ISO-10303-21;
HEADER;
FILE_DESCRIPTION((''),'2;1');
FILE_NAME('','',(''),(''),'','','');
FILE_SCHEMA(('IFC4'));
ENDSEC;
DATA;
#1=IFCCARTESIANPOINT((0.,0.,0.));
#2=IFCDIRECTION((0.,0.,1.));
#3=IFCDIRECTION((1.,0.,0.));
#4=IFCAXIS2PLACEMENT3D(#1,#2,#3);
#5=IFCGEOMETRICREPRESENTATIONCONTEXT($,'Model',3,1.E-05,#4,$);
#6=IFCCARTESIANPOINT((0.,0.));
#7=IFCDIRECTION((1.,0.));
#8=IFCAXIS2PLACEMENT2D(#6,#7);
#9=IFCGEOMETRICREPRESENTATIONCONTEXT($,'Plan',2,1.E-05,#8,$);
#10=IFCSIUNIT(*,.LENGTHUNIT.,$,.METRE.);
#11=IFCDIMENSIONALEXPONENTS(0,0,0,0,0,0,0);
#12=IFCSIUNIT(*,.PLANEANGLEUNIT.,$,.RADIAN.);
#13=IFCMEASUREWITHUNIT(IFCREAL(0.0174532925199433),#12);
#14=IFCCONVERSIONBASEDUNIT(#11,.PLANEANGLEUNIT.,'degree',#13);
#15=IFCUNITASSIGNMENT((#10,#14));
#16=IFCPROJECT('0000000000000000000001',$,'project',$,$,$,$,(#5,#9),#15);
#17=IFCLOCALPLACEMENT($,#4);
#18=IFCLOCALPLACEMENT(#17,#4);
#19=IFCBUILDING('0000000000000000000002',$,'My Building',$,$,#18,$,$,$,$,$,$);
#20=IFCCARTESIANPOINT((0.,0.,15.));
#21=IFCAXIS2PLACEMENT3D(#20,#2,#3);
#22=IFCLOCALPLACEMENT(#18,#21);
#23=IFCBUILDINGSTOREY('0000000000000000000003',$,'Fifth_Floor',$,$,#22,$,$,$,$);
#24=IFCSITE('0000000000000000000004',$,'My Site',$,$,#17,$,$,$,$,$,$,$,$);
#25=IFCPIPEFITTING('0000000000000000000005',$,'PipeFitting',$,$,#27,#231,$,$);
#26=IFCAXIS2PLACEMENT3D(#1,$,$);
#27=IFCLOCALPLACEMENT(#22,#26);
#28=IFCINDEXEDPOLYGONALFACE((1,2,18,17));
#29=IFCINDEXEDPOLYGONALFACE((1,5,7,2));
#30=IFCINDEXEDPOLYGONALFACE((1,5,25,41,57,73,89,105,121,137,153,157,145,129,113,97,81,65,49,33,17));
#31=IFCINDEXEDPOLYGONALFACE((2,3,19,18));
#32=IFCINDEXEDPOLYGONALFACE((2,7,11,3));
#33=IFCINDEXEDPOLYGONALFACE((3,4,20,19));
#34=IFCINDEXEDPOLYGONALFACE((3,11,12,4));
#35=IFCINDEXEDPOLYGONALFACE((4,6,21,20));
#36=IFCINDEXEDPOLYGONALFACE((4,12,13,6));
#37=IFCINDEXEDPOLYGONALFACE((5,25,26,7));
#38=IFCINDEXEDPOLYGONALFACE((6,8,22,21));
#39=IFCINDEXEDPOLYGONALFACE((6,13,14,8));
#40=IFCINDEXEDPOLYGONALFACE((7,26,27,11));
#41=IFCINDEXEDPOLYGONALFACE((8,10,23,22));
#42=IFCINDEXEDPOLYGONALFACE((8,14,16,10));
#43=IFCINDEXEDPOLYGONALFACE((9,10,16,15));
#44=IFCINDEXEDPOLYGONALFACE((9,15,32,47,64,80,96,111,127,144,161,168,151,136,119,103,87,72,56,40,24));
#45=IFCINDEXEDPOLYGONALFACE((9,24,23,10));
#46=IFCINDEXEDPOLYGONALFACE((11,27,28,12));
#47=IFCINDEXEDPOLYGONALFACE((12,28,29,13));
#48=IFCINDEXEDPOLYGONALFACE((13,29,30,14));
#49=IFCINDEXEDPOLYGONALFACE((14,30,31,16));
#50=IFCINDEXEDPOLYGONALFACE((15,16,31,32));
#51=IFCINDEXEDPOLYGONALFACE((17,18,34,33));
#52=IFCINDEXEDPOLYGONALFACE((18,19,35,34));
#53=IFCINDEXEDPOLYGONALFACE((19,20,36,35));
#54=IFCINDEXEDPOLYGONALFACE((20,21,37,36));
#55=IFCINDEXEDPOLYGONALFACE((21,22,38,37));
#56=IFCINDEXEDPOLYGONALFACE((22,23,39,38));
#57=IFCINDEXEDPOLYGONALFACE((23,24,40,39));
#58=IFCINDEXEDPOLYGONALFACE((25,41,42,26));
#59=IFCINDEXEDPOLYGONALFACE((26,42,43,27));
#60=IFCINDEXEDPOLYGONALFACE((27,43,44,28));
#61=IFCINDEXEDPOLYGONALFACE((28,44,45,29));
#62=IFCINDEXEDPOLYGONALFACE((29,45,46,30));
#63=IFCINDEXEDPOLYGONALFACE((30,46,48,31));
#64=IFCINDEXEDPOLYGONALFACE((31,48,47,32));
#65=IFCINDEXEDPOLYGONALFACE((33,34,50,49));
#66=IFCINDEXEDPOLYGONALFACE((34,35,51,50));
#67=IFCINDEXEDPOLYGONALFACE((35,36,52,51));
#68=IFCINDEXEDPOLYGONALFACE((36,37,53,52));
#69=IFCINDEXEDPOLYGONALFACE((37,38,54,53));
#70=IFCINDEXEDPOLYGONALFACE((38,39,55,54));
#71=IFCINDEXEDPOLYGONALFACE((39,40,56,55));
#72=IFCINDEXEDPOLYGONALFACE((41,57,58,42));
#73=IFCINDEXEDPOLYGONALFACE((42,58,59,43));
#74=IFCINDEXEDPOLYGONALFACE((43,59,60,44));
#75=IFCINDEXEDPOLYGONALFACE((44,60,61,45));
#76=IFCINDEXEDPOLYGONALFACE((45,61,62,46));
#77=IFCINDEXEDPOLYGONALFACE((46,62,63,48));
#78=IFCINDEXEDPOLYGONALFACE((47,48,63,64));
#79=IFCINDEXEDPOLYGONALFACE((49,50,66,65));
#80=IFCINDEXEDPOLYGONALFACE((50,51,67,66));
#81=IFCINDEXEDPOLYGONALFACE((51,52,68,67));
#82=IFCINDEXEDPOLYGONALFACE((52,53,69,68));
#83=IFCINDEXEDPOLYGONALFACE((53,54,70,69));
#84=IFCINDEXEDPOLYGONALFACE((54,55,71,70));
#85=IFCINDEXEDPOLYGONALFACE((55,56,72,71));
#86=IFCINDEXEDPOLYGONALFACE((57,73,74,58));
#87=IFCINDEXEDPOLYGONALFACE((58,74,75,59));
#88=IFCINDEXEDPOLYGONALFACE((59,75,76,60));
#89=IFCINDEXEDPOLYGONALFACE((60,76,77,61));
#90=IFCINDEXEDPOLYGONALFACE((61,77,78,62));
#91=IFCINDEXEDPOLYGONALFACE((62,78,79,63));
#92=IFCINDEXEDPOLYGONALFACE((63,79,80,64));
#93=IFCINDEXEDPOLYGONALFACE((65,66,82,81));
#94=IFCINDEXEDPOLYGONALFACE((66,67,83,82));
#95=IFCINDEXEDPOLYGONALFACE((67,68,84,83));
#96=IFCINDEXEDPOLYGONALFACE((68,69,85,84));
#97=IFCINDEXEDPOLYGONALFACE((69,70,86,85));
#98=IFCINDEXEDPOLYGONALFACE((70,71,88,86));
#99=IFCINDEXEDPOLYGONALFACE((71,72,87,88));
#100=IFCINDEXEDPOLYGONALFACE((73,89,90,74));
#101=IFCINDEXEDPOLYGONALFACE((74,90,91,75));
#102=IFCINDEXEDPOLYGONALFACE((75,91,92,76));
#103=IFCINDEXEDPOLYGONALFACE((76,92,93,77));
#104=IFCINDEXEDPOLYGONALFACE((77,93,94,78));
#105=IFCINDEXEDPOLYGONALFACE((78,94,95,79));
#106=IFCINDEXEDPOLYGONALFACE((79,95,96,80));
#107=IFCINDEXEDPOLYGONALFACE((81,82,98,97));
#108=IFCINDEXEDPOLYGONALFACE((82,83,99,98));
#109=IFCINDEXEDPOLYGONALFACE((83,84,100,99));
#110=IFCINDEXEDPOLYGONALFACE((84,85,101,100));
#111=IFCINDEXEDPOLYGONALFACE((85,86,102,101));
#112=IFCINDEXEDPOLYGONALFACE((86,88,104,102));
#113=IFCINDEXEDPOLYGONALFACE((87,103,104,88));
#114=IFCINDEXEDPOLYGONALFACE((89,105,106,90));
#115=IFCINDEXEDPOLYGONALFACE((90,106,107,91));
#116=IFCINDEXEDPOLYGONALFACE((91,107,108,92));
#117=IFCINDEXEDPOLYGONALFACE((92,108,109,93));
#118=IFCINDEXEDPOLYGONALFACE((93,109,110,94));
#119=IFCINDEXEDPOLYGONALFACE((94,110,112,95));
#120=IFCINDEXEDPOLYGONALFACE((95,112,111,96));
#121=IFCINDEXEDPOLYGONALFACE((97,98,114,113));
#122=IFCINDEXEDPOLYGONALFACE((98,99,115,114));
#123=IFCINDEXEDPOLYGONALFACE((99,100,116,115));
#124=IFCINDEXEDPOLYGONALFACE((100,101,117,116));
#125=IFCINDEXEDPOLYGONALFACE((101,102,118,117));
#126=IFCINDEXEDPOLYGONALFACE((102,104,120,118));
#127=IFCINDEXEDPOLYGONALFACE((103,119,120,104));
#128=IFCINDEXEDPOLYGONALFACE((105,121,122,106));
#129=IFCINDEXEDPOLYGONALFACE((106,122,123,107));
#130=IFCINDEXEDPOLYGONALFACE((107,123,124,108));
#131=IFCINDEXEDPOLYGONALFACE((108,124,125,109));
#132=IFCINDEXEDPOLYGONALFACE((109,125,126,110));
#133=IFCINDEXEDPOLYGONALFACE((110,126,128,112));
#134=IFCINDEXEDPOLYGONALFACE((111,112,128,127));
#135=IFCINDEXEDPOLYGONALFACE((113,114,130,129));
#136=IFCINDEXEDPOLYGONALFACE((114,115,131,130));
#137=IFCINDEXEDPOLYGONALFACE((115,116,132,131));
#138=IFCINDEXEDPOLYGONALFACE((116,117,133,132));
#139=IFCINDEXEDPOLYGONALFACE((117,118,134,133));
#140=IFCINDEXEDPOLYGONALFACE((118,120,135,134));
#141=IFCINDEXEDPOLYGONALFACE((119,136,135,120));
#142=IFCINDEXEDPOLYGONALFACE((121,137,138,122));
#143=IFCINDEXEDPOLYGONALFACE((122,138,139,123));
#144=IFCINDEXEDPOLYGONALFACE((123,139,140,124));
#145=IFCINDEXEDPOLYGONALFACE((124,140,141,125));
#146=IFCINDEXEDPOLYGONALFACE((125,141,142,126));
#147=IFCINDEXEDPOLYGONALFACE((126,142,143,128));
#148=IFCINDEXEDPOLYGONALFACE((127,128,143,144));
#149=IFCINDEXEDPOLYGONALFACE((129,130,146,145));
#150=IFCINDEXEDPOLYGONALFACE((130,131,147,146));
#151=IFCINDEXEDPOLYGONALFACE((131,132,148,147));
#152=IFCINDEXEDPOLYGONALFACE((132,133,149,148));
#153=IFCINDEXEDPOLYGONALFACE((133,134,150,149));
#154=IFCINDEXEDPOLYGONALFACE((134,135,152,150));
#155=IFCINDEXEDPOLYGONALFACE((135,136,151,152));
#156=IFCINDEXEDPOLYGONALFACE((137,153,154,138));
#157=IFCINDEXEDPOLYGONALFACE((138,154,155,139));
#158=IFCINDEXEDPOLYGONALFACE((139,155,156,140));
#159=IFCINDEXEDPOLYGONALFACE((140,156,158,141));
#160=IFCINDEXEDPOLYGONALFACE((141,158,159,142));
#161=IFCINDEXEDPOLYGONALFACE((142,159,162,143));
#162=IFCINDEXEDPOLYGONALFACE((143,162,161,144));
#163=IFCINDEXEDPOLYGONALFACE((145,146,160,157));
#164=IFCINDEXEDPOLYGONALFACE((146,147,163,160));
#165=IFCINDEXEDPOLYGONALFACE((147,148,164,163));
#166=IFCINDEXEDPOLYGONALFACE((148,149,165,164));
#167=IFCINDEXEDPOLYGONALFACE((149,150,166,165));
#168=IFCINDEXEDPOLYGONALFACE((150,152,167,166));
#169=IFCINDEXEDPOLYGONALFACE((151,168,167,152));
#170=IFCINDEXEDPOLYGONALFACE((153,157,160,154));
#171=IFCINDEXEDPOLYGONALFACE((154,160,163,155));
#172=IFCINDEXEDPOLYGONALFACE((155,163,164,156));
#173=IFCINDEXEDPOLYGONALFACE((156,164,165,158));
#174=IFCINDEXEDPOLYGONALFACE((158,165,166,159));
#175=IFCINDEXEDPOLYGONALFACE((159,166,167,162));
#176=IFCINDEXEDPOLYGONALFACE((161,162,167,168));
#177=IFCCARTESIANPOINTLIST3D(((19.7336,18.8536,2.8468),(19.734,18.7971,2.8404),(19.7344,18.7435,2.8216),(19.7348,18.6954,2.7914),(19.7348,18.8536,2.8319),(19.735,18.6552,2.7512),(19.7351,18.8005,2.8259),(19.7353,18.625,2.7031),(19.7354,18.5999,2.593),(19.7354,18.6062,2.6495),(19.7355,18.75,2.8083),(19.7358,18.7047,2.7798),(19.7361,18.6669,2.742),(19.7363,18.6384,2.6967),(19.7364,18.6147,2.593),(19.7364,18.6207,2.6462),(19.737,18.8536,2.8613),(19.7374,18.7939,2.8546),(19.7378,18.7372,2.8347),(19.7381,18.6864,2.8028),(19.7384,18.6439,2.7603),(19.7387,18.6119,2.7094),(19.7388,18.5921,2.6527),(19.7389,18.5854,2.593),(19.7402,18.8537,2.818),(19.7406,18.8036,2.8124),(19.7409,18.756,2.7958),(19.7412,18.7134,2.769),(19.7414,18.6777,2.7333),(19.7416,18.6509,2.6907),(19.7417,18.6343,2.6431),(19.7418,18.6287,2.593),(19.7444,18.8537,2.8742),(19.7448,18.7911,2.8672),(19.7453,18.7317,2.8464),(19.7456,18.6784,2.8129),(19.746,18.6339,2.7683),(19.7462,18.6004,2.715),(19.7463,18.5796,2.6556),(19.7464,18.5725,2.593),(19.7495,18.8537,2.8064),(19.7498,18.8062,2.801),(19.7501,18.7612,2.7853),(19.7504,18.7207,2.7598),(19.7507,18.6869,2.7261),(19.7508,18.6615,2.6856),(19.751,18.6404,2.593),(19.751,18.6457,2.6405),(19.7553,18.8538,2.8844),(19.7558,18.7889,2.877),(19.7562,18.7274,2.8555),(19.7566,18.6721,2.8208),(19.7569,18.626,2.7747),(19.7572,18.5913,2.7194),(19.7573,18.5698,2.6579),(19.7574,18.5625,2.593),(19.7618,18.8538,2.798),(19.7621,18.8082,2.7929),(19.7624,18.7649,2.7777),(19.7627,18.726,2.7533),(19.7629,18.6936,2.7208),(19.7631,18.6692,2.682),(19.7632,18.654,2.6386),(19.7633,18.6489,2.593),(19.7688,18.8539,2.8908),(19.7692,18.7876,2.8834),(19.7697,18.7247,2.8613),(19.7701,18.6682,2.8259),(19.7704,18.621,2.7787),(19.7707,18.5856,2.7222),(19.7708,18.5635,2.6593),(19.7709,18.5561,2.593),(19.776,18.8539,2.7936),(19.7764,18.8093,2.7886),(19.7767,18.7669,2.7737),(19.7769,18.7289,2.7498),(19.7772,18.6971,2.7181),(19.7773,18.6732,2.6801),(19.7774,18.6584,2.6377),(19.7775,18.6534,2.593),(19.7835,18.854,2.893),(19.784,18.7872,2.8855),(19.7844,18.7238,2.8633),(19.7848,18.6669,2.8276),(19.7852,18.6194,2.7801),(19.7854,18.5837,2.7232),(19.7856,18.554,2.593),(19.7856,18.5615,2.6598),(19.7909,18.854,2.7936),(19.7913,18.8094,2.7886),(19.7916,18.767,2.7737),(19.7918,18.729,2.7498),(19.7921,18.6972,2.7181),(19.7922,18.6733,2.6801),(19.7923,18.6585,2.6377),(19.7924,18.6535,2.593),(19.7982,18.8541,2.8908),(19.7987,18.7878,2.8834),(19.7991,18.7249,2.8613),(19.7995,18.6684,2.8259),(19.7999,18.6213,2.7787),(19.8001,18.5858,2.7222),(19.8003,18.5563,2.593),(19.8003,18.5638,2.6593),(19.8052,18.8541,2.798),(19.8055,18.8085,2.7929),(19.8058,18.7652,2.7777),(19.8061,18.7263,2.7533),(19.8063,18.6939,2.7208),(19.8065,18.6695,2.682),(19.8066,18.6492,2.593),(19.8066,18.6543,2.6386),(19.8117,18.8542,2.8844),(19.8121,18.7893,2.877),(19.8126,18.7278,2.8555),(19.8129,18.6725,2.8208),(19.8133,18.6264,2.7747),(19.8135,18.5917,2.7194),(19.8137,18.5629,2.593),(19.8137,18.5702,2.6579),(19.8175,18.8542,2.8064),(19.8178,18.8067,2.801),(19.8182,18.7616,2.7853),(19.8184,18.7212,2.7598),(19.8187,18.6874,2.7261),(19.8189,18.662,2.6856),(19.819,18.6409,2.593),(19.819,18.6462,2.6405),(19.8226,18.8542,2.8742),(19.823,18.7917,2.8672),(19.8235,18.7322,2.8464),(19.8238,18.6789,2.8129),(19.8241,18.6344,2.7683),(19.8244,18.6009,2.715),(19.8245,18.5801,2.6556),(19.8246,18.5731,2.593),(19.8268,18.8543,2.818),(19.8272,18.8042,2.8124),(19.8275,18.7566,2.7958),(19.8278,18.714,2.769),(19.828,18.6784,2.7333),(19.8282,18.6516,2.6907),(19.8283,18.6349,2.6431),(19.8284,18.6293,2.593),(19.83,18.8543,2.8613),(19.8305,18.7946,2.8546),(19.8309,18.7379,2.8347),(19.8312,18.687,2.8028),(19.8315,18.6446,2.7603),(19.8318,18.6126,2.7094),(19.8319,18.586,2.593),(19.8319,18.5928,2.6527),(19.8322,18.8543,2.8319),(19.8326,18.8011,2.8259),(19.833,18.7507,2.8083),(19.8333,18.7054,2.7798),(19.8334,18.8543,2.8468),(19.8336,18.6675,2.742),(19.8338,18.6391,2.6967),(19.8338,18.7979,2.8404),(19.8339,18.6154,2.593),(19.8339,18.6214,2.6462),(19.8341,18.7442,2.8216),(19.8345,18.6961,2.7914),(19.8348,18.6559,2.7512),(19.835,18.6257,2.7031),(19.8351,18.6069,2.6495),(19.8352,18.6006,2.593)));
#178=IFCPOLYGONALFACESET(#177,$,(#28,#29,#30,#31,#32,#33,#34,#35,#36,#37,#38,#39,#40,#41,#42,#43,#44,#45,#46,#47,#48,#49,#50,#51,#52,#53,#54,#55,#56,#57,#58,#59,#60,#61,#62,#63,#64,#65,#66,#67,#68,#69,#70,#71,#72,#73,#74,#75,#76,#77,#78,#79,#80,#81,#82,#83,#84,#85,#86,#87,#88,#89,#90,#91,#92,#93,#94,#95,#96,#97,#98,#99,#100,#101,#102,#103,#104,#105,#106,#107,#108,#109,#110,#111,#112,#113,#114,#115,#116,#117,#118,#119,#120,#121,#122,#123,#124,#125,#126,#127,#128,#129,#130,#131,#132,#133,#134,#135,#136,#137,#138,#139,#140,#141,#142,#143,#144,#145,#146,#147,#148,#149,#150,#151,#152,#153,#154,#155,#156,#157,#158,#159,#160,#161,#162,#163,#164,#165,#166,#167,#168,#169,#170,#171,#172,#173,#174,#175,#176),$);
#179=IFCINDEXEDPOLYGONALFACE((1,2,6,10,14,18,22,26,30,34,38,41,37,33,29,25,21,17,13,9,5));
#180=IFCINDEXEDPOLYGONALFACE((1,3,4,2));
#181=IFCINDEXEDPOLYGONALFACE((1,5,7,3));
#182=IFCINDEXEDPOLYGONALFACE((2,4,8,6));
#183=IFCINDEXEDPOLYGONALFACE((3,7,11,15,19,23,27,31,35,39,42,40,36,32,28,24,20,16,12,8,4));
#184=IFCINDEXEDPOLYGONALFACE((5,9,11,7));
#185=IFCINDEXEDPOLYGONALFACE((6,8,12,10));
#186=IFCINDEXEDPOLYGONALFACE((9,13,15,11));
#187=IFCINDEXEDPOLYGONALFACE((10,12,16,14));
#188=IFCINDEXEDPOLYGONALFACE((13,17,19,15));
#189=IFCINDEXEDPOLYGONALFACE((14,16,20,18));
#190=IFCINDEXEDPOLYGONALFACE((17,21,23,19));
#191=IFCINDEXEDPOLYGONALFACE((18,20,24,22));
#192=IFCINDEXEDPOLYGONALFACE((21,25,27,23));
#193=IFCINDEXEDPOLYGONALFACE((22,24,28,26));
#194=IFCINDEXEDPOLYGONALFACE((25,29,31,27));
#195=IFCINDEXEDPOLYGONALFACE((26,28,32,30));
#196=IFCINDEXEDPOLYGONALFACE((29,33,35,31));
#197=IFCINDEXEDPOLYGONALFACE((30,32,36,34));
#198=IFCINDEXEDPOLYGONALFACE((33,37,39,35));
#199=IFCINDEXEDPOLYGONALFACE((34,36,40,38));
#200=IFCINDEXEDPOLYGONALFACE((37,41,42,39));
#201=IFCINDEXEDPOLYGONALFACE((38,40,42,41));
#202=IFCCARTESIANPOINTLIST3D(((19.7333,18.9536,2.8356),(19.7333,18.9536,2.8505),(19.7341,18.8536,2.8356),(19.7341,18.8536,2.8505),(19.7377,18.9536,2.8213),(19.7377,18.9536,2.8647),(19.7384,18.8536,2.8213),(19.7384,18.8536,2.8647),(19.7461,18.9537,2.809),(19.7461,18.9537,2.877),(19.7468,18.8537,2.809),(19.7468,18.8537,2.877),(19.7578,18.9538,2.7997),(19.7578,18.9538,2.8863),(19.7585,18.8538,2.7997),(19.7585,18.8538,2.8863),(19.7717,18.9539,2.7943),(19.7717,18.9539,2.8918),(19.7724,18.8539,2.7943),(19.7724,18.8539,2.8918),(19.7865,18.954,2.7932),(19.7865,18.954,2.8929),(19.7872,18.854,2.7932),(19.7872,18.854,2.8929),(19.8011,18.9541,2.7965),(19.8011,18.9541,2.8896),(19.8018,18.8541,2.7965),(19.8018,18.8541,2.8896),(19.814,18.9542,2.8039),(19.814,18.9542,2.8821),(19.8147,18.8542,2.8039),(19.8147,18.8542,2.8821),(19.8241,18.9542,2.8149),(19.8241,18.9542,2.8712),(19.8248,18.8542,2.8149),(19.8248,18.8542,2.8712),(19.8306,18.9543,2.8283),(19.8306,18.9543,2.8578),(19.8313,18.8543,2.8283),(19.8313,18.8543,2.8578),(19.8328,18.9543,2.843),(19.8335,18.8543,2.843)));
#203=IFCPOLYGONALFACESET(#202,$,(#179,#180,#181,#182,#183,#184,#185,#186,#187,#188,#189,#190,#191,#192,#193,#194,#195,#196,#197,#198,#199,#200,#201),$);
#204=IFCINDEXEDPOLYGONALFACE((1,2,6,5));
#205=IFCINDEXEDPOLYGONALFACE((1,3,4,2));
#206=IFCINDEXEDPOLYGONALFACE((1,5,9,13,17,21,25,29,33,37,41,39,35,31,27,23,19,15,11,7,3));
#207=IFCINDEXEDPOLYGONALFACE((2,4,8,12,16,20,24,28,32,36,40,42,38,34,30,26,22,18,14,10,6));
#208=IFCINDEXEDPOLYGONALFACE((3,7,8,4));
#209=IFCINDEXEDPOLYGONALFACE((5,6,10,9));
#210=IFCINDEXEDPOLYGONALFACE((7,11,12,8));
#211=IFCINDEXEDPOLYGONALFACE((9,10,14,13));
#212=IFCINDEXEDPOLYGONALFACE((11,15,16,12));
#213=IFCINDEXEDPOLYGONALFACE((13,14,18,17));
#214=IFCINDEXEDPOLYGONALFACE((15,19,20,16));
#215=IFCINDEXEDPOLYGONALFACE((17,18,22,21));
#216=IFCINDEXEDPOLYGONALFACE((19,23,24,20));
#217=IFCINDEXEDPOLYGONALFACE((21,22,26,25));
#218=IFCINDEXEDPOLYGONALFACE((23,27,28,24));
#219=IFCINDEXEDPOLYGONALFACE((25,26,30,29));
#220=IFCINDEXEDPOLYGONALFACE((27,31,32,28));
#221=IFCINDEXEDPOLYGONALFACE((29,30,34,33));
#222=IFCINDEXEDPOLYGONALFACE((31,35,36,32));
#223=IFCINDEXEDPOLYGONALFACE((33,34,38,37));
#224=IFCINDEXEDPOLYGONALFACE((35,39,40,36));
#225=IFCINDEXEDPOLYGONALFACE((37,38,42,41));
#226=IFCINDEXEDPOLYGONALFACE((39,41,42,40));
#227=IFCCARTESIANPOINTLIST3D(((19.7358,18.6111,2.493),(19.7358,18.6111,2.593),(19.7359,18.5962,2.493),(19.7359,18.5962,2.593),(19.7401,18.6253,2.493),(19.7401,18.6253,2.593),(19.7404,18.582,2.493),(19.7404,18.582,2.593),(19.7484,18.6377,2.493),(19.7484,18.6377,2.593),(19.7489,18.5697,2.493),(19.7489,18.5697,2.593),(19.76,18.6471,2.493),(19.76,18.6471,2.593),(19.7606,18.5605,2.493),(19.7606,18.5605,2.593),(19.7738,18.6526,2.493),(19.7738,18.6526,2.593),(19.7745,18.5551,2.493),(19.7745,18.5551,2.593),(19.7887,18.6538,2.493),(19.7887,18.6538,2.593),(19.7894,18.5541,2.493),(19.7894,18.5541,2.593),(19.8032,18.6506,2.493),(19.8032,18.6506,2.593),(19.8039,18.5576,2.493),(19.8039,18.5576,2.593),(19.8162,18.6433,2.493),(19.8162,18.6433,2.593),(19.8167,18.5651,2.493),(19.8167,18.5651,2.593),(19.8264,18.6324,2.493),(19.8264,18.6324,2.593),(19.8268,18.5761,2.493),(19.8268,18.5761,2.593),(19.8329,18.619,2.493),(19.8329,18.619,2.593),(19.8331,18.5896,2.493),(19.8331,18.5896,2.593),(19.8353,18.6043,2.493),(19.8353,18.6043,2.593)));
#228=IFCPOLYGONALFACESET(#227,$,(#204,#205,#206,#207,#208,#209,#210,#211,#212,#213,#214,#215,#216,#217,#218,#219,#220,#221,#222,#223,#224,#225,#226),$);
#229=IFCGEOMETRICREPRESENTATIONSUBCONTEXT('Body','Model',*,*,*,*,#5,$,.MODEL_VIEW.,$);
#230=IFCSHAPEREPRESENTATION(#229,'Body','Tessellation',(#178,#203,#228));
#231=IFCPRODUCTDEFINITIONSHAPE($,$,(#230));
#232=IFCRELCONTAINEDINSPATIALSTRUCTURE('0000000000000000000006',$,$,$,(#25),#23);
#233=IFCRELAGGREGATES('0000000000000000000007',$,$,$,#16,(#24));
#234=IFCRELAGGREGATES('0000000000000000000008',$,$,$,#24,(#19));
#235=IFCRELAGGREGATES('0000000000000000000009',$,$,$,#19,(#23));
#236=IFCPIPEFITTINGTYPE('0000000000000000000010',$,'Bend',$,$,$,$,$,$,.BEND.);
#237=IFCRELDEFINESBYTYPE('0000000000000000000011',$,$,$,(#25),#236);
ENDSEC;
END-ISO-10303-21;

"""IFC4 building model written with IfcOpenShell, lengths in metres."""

from ifc_helpers import new_model, entity, si_unit, converted_unit, frame, origin_with_axes, origin_2d_with_axis, place, context, subcontext, project, spatial, circle, extrude, source, transform, mapped, type_object, type_shapes, element, save


model = new_model("IFC4")

# Units and contexts
model_context = context("Model", 3, precision=1e-05, world=origin_with_axes())
plan_context = context("Plan", 2, precision=1e-05, world=origin_2d_with_axis())
body_context_1 = subcontext(model_context, "Body", "Model", "MODEL_VIEW")
ifc_project = project(units=[si_unit("LENGTHUNIT", "METRE"), converted_unit("PLANEANGLEUNIT", "degree", entity("IfcReal", 0.0174532925199433), si_unit("PLANEANGLEUNIT", "RADIAN"), dimensions=[0, 0, 0, 0, 0, 0, 0])], contexts=[model_context, plan_context])

# Site, building, storey
site_placement = place(None, origin_with_axes())
site = spatial("IfcSite", under=ifc_project, at=site_placement, Name="My Site")
building_placement = place(site_placement, origin_with_axes())
building = spatial("IfcBuilding", under=site, at=building_placement, Name="My Building")
storey_placement = place(building_placement, frame((0.0, 0.0, 15.0), z_axis=(0.0, 0.0, 1.0), x_axis=(1.0, 0.0, 0.0)))
storey = spatial("IfcBuildingStorey", under=building, at=storey_placement, Name="Fifth_Floor")

# Pipe fitting
pipe_fitting_type = type_object("IfcPipeFittingType", Name="Bend", PredefinedType="BEND")
shared_shape_1 = source(origin_with_axes(), body_context_1, "Body", "SolidModel", [
    entity("IfcSweptDiskSolid", entity("IfcIndexedPolyCurve", entity("IfcCartesianPointList3D", [[0.0, 0.0, -0.1], [0.0, 0.0732, -0.2768], [0.0, 0.25, -0.35]]), [entity("IfcArcIndex", [1, 2, 3])]), 0.05),
    extrude(circle(Radius=0.05), origin_with_axes(), (0.0, 0.0, -1.0), 0.1),
    extrude(circle(Radius=0.05), frame((0.0, 0.25, -0.35), z_axis=(0.0, 1.0, 0.0), x_axis=(1.0, 0.0, 0.0)), (0.0, 0.0, 1.0), 0.1),
])
type_shapes(pipe_fitting_type, [shared_shape_1])
for number, where, z_axis, x_axis, name in (
    (1, (19.7828, 18.954, 2.843), (-0.007084, 0.999975, 0.0), (0.999975, 0.007084, 0.0), "PipeFitting"),
):
    element("IfcPipeFitting", number, at=place(storey_placement, frame(where, z_axis=z_axis, x_axis=x_axis)), inside=storey, type_object=pipe_fitting_type, Name=name, context=body_context_1, shape_type="MappedRepresentation", body=[
        mapped(shared_shape_1, transform((0.0, 0.0, 0.0), x_axis=(1.0, 0.0, 0.0), y_axis=(0.0, 1.0, 0.0), z_axis=(0.0, 0.0, 1.0), scale=1.0)),
    ])

save(model, "model.ifc")
